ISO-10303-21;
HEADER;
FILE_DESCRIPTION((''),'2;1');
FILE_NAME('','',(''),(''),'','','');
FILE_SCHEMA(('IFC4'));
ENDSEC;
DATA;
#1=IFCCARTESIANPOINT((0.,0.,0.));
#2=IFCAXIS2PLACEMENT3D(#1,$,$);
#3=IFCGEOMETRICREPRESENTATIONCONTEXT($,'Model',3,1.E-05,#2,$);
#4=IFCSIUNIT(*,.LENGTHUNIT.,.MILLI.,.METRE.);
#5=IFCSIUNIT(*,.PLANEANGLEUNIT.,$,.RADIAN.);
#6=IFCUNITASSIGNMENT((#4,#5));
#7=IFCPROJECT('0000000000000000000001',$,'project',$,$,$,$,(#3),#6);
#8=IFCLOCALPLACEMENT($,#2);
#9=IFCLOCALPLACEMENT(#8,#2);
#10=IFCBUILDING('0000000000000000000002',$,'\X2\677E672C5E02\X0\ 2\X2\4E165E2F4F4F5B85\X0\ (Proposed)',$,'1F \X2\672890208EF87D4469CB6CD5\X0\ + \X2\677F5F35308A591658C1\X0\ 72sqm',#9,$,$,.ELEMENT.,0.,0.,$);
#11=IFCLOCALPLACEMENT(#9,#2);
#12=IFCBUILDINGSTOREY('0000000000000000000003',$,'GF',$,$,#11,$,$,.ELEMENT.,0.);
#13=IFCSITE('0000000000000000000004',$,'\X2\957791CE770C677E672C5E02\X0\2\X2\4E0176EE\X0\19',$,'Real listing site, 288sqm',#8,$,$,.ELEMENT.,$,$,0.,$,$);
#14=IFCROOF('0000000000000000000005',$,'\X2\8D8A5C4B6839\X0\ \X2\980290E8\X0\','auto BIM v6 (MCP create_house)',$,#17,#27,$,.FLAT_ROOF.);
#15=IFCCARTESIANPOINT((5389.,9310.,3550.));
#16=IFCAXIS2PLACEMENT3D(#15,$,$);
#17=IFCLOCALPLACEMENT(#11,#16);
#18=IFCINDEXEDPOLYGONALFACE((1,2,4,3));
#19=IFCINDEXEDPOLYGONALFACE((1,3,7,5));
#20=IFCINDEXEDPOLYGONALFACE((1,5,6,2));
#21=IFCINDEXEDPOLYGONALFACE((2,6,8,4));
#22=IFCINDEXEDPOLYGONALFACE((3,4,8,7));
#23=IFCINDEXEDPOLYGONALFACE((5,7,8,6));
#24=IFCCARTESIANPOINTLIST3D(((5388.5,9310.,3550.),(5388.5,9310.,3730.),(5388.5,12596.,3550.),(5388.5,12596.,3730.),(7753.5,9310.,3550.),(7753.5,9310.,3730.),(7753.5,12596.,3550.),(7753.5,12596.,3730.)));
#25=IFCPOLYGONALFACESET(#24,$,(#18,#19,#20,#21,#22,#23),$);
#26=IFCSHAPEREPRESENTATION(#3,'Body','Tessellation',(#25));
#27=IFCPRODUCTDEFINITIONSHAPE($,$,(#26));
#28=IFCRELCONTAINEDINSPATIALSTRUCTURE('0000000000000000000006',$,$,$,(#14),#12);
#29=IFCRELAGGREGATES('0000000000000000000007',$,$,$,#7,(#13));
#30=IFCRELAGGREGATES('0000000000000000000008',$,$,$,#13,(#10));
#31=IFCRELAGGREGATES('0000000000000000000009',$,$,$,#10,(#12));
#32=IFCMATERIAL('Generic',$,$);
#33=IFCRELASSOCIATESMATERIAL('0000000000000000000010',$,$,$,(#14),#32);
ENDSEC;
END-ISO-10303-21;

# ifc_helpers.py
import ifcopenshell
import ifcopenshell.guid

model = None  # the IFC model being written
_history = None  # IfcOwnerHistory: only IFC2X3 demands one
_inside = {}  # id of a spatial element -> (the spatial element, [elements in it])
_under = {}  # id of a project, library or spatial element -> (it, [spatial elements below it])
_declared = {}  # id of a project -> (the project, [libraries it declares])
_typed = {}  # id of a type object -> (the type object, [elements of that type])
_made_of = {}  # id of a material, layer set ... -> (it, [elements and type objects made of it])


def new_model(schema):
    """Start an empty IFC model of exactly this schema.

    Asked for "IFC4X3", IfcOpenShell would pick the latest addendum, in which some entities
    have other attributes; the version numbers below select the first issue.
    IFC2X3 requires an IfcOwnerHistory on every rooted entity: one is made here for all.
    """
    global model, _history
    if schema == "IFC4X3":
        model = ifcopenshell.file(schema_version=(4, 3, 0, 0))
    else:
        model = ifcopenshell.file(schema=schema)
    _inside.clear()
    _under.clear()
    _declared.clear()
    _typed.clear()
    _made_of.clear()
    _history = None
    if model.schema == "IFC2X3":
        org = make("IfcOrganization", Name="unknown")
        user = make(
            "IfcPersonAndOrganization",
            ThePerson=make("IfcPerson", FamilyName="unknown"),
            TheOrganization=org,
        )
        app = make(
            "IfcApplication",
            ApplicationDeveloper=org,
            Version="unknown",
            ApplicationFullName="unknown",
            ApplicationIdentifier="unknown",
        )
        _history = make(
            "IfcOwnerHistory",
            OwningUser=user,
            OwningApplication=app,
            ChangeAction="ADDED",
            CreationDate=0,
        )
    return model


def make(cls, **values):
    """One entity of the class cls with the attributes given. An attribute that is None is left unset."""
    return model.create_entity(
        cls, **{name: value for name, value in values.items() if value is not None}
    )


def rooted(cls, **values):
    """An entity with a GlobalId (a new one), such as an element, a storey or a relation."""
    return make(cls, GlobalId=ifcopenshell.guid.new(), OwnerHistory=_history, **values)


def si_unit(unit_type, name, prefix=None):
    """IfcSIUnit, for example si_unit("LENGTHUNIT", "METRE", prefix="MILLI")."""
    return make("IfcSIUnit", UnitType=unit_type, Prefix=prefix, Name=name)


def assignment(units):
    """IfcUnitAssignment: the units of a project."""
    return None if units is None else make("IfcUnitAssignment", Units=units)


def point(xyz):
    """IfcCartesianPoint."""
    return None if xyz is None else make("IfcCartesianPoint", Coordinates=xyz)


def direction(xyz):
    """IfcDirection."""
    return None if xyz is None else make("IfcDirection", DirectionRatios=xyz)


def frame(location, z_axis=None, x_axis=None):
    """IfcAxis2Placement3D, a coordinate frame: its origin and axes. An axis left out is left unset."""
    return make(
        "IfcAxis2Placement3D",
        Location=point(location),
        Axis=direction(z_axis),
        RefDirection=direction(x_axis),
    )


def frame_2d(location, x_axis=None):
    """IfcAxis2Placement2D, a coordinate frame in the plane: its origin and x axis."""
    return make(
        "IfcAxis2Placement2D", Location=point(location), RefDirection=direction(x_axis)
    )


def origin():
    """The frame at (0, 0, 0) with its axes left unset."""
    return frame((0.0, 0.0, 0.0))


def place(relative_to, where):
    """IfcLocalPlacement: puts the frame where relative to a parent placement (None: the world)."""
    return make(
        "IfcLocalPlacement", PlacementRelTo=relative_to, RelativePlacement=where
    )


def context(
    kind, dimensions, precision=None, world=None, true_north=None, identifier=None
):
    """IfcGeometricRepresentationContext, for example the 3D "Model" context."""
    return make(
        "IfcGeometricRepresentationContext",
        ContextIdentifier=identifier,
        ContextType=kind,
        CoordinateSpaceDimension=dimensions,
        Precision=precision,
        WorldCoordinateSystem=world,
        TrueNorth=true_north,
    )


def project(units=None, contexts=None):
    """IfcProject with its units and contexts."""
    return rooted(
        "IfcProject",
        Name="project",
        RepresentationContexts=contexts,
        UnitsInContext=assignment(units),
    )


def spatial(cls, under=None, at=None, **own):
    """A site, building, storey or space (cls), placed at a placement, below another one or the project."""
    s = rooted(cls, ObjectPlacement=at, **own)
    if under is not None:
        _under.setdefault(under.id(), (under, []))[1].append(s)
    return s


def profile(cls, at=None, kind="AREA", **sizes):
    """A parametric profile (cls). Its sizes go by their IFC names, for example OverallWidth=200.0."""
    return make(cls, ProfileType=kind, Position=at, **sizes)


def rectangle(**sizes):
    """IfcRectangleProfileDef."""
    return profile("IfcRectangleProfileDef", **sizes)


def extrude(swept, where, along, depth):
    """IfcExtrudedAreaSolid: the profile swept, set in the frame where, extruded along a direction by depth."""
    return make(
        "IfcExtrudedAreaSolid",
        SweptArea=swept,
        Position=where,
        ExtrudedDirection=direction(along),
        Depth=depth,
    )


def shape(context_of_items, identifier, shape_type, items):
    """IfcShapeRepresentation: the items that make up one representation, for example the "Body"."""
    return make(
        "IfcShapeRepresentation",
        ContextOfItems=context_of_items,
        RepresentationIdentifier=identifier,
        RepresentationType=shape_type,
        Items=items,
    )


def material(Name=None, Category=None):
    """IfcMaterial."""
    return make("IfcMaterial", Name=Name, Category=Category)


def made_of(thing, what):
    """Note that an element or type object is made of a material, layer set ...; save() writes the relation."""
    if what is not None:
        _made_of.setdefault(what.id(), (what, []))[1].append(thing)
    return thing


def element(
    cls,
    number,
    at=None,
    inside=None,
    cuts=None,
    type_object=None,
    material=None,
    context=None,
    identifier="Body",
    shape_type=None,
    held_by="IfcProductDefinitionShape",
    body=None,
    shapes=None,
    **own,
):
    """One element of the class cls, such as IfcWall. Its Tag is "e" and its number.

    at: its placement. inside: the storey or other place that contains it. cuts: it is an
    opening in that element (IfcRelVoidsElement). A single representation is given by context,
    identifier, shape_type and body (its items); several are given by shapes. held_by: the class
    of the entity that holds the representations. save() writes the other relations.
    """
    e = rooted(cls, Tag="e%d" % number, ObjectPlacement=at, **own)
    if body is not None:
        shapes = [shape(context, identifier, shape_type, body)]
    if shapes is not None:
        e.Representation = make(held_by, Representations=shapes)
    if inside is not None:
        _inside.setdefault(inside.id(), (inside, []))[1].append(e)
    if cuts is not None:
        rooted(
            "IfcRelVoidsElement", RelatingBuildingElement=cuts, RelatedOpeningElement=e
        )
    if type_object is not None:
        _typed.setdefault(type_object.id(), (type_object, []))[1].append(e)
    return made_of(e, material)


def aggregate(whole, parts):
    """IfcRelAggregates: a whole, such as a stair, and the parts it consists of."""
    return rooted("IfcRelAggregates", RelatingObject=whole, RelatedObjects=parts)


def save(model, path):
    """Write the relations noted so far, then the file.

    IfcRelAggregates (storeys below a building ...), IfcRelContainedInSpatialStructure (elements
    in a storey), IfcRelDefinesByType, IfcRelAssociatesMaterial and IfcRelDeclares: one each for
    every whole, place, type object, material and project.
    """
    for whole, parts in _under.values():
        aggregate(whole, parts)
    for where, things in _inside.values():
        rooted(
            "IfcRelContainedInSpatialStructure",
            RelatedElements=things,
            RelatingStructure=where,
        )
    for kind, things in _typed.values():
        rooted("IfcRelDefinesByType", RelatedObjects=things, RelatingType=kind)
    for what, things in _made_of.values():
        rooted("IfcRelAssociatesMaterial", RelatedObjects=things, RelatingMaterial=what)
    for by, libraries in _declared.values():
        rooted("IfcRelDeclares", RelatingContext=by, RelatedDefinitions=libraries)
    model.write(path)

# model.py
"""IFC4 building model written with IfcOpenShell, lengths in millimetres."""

from ifc_helpers import new_model, si_unit, frame, frame_2d, origin, place, context, project, spatial, rectangle, extrude, material, element, save


model = new_model("IFC4")

# Units and contexts
model_context = context("Model", 3, precision=1e-05, world=origin())
ifc_project = project(units=[si_unit("LENGTHUNIT", "METRE", prefix="MILLI"), si_unit("PLANEANGLEUNIT", "RADIAN")], contexts=[model_context])

# Site, building, storey
site_placement = place(None, origin())
site = spatial("IfcSite", under=ifc_project, at=site_placement, Name="長野県松本市2丁目19", ObjectType="Real listing site, 288sqm", CompositionType="ELEMENT", RefElevation=0.0)
building_placement = place(site_placement, origin())
building = spatial("IfcBuilding", under=site, at=building_placement, Name="松本市 2世帯住宅 (Proposed)", ObjectType="1F 木造軸組構法 + 板張り外壁 72sqm", CompositionType="ELEMENT", ElevationOfRefHeight=0.0, ElevationOfTerrain=0.0)
storey_placement = place(building_placement, origin())
storey = spatial("IfcBuildingStorey", under=building, at=storey_placement, Name="GF", CompositionType="ELEMENT", Elevation=0.0)

# Shared definitions
ifc_material = material(Name="Generic")

# Roof
roof_1_placement = place(storey_placement, frame((5389.0, 9310.0, 3550.0)))
element("IfcRoof", 1, at=roof_1_placement, inside=storey, material=ifc_material, Name="越屋根 頂部", Description="auto BIM v6 (MCP create_house)", PredefinedType="FLAT_ROOF", context=model_context, shape_type="SweptSolid", body=[
    extrude(rectangle(XDim=2365.0, YDim=3286.0, at=frame_2d((1182.0, 1643.0))), frame((5389.0, 9310.0, 3550.0)), (0.0, 0.0, 1.0), 180.0),
])

save(model, "model.ifc")
